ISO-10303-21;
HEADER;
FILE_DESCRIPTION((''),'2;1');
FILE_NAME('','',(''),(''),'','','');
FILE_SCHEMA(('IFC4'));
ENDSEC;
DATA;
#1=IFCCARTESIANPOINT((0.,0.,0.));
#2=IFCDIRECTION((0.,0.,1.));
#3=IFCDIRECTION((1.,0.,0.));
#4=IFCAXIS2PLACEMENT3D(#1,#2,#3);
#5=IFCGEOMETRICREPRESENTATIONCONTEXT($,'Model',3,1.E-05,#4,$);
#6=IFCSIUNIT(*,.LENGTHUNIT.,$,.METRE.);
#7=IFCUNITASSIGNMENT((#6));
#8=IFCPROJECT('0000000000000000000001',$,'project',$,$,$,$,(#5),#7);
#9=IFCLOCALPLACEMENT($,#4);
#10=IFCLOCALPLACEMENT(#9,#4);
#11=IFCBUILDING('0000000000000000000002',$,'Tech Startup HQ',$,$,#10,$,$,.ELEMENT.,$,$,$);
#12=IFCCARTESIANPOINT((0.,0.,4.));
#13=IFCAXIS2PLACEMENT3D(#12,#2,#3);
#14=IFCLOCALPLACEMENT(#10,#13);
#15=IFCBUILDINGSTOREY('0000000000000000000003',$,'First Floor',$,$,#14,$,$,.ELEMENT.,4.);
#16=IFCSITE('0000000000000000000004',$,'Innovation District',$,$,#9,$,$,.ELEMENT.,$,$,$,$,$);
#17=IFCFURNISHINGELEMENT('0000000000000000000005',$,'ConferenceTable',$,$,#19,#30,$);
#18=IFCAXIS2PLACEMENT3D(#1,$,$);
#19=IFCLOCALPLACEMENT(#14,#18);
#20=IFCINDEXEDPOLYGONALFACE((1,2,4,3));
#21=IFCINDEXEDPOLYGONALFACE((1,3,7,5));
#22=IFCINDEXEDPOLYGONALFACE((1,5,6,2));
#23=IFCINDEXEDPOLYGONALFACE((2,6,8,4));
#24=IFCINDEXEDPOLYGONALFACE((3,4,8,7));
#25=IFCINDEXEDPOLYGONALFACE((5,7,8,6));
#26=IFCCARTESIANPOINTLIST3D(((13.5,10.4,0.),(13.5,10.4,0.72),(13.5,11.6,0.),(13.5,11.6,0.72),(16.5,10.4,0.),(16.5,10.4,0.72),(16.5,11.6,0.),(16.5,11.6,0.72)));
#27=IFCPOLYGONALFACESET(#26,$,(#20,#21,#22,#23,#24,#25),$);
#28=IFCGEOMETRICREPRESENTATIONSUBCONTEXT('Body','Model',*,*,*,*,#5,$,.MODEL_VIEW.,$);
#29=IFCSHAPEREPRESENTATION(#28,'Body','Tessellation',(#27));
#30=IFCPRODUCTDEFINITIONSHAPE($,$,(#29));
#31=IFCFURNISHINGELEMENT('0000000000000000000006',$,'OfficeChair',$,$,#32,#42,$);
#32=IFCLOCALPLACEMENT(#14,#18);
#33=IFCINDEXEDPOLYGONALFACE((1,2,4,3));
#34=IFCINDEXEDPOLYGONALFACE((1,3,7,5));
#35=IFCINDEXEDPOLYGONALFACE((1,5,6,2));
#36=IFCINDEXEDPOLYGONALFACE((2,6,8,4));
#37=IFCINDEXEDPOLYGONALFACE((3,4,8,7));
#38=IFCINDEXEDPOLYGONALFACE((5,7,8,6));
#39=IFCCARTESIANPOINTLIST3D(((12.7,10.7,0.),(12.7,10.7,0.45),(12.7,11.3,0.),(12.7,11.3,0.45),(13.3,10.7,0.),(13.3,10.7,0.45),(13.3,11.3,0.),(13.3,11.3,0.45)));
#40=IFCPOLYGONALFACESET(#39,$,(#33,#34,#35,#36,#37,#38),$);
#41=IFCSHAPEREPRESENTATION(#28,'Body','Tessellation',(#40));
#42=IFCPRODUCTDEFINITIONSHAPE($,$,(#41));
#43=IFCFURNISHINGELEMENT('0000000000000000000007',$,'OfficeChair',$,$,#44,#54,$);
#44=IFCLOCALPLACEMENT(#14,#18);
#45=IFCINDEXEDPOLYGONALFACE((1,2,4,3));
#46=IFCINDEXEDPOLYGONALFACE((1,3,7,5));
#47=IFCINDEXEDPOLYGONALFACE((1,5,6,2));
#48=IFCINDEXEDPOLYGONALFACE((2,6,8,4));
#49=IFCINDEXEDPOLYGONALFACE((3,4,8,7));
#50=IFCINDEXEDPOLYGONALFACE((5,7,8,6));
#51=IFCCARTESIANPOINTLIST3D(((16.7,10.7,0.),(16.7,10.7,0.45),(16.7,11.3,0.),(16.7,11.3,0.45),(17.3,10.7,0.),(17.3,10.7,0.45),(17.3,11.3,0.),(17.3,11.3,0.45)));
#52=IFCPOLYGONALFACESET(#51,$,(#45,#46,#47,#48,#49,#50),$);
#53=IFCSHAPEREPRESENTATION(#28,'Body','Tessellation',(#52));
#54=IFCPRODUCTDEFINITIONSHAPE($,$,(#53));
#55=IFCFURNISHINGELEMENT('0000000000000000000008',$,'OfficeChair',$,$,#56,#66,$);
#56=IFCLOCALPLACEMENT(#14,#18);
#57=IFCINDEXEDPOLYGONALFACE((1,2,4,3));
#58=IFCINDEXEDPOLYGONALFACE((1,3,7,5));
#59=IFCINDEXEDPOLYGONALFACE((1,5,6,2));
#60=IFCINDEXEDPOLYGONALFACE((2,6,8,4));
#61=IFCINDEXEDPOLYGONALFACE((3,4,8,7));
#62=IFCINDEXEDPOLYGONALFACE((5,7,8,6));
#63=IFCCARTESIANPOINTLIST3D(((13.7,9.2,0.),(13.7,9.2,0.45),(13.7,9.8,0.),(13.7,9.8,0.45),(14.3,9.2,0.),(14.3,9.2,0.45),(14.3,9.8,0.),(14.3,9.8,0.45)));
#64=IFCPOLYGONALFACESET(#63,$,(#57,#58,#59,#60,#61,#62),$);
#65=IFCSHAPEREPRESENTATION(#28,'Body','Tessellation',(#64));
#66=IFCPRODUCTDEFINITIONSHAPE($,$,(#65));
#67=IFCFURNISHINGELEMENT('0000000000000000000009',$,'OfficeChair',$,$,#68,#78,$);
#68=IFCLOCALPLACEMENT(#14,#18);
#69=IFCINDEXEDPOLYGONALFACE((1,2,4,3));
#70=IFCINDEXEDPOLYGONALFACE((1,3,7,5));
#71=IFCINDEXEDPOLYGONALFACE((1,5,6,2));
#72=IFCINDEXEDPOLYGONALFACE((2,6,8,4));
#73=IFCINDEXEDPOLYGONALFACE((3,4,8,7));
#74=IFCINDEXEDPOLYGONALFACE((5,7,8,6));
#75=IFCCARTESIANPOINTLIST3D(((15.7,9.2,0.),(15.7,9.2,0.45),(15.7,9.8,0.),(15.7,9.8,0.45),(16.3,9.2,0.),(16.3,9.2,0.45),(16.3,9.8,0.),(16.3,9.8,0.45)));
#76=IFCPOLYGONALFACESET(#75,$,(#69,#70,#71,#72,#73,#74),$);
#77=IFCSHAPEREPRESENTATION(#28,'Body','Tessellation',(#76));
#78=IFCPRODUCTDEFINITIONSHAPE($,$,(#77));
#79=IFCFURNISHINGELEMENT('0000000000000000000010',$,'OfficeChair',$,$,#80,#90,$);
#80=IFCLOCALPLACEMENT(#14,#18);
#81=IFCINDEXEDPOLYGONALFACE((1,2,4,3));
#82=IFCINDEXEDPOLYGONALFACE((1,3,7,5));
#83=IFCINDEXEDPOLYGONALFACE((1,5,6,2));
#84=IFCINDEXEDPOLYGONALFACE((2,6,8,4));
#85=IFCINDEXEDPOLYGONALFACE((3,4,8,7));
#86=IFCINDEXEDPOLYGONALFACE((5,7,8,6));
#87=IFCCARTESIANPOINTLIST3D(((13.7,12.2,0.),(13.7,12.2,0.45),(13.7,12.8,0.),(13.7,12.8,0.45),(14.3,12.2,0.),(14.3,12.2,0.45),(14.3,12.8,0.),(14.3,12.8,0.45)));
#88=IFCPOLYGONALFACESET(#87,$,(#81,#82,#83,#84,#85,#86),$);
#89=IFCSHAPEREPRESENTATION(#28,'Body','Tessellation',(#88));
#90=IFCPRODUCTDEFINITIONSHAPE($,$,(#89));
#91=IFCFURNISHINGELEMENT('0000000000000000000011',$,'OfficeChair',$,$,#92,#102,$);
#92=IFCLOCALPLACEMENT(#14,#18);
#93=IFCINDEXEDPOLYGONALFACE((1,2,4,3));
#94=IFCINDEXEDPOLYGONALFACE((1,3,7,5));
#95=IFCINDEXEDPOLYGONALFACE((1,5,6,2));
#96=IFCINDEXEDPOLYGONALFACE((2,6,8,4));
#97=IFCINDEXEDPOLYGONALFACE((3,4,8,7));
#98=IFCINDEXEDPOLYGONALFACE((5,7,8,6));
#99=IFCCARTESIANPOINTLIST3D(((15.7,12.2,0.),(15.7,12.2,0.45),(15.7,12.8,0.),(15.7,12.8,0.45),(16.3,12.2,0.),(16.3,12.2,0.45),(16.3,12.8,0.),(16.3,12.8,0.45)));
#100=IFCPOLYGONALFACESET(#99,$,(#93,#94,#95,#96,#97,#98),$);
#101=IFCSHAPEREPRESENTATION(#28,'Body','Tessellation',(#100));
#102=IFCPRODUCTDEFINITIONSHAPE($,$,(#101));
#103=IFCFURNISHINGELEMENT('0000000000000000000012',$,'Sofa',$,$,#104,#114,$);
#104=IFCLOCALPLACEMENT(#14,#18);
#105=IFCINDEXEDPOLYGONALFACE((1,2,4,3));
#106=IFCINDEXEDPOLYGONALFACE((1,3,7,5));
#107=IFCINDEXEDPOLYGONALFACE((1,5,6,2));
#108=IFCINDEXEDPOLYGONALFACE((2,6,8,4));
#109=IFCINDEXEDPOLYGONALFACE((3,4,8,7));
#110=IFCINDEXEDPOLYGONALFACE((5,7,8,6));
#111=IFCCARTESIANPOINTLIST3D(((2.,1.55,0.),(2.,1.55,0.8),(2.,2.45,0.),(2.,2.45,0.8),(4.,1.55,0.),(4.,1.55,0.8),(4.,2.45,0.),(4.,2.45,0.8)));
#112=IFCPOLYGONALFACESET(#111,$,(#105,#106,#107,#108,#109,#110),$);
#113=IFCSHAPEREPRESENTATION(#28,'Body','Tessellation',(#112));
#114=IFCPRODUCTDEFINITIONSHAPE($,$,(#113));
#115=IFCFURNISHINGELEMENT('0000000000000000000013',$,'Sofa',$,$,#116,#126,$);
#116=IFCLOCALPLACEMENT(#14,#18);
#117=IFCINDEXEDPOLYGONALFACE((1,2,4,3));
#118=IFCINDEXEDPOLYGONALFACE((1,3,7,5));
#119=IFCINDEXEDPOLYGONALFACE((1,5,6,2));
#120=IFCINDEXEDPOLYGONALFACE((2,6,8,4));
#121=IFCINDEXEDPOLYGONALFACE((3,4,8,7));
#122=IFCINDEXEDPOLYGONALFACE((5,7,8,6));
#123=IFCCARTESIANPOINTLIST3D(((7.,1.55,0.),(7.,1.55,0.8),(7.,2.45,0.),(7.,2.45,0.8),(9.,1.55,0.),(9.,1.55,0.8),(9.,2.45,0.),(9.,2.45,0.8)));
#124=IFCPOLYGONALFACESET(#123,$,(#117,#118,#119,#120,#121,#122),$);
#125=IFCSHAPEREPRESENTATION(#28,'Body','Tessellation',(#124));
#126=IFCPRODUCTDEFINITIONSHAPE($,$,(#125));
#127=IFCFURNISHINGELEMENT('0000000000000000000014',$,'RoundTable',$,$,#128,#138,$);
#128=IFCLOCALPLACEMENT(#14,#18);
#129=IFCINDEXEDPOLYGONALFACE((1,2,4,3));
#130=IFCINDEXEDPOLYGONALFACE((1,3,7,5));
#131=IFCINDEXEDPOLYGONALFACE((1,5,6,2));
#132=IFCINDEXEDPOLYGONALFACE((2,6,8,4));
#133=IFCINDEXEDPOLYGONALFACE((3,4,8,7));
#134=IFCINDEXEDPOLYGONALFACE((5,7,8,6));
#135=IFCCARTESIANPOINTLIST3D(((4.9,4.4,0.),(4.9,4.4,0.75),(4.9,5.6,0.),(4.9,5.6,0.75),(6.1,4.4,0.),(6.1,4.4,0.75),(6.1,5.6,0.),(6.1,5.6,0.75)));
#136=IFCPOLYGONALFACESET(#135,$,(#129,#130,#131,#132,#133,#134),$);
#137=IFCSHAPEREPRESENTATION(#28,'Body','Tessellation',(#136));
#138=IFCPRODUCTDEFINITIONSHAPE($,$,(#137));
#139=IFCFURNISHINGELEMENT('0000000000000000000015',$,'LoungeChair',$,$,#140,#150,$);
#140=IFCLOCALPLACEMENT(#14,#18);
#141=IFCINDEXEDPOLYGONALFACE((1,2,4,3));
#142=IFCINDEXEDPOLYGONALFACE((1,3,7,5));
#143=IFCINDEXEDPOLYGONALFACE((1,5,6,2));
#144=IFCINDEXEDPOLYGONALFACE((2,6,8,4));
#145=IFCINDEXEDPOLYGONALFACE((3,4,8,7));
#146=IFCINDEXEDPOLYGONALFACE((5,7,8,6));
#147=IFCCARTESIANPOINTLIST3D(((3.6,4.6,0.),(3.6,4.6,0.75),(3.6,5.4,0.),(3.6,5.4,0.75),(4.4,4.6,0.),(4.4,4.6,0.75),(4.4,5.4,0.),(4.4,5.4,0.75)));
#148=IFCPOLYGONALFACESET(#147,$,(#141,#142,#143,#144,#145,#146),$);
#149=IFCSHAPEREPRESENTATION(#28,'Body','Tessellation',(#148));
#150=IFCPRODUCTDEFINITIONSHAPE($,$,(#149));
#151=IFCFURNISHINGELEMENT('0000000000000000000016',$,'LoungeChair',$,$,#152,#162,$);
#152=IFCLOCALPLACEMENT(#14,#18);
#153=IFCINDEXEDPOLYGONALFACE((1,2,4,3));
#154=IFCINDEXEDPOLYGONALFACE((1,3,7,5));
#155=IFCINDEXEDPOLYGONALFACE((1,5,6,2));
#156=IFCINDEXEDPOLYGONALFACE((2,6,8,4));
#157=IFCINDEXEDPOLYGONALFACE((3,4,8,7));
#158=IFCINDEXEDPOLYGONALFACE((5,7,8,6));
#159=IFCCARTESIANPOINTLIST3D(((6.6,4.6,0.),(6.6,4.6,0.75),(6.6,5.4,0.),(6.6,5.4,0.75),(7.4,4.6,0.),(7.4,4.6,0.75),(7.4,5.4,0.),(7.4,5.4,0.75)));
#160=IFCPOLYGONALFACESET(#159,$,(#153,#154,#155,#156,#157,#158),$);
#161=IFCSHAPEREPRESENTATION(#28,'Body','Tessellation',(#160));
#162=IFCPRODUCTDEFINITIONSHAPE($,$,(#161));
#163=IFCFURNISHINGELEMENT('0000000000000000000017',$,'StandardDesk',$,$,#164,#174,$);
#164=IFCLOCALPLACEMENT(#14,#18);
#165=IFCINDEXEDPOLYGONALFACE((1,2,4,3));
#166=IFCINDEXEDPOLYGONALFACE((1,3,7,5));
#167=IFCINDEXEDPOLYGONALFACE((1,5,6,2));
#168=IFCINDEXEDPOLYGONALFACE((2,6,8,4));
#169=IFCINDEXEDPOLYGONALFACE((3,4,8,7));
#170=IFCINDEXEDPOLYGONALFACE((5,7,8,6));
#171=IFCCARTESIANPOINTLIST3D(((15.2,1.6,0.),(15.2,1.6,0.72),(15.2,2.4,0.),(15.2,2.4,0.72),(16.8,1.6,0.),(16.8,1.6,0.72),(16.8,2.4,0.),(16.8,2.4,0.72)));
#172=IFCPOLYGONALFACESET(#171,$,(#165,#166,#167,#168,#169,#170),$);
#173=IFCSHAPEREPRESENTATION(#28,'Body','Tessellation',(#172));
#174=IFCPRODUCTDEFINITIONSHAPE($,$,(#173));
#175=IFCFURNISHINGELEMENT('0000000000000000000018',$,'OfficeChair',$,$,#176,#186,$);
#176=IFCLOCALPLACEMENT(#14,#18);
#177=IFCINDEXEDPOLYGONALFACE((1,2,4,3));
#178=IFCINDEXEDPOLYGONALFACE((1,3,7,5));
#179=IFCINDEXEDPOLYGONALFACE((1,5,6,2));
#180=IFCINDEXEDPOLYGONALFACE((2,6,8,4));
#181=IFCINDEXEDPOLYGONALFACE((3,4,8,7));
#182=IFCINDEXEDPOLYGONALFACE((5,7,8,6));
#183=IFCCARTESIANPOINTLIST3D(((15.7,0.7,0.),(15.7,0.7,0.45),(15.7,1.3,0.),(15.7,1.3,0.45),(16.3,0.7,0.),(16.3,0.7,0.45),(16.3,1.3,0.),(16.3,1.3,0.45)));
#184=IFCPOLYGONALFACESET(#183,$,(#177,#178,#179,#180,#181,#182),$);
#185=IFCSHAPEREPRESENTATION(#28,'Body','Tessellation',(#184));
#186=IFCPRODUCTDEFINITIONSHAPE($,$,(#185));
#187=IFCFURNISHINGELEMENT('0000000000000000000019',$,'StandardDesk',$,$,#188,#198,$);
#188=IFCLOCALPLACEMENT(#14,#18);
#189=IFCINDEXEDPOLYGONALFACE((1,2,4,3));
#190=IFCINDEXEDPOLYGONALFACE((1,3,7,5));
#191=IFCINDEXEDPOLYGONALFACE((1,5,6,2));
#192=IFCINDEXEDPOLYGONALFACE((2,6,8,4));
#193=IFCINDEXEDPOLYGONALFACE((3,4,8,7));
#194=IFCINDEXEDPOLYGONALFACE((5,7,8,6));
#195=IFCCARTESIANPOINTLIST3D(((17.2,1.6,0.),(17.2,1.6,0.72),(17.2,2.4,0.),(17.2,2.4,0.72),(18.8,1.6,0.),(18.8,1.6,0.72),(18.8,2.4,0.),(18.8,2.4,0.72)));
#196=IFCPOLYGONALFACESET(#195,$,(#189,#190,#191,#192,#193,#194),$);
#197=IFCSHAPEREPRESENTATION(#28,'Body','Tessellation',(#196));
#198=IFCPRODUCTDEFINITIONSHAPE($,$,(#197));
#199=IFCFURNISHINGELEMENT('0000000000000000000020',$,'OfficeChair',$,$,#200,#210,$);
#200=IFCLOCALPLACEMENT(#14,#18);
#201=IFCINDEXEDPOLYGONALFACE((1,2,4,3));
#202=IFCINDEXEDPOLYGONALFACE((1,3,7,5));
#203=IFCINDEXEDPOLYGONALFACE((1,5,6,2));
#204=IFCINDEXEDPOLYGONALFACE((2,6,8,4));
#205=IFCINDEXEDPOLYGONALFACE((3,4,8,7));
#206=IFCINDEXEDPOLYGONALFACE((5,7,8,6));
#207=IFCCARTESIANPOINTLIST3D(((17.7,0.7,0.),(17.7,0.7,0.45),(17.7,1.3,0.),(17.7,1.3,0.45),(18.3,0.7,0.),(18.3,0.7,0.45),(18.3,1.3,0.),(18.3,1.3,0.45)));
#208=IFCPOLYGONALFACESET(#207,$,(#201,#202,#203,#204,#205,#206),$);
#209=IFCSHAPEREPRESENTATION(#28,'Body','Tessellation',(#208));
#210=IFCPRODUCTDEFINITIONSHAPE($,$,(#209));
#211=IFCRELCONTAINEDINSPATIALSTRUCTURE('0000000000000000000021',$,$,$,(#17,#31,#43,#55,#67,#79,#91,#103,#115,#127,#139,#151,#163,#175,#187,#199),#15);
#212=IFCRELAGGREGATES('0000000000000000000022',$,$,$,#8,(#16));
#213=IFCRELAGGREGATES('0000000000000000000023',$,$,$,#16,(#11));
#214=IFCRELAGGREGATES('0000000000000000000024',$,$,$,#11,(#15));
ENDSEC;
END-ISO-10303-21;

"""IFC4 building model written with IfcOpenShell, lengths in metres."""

from ifc_helpers import new_model, si_unit, frame, origin_with_axes, place, context, subcontext, project, spatial, polyline, outline, extrude, element, save


model = new_model("IFC4")

# Units and contexts
model_context = context("Model", 3, precision=1e-05, world=origin_with_axes())
body_context = subcontext(model_context, "Body", "Model", "MODEL_VIEW")
ifc_project = project(units=[si_unit("LENGTHUNIT", "METRE")], contexts=[model_context])

# Site, building, storey
site_placement = place(None, origin_with_axes())
site = spatial("IfcSite", under=ifc_project, at=site_placement, Name="Innovation District", CompositionType="ELEMENT")
building_placement = place(site_placement, origin_with_axes())
building = spatial("IfcBuilding", under=site, at=building_placement, Name="Tech Startup HQ", CompositionType="ELEMENT")
storey_placement = place(building_placement, frame((0.0, 0.0, 4.0), z_axis=(0.0, 0.0, 1.0), x_axis=(1.0, 0.0, 0.0)))
storey = spatial("IfcBuildingStorey", under=building, at=storey_placement, Name="First Floor", CompositionType="ELEMENT", Elevation=4.0)

# Furnishing elements
furnishing_1_placement = place(storey_placement, origin_with_axes())
element("IfcFurnishingElement", 1, at=furnishing_1_placement, inside=storey, Name="ConferenceTable", context=body_context, shape_type="SweptSolid", body=[
    extrude(outline(polyline([(13.5, 10.4, 0.0), (16.5, 10.4, 0.0), (16.5, 11.6, 0.0), (13.5, 11.6, 0.0), (13.5, 10.4, 0.0)])), None, (0.0, 0.0, 1.0), 0.72),
])
furnishing_2_placement = place(storey_placement, origin_with_axes())
element("IfcFurnishingElement", 2, at=furnishing_2_placement, inside=storey, Name="OfficeChair", context=body_context, shape_type="SweptSolid", body=[
    extrude(outline(polyline([(12.7, 11.3, 0.0), (12.7, 10.7, 0.0), (13.3, 10.7, 0.0), (13.3, 11.3, 0.0), (12.7, 11.3, 0.0)])), None, (0.0, 0.0, 1.0), 0.45),
])
furnishing_3_placement = place(storey_placement, origin_with_axes())
element("IfcFurnishingElement", 3, at=furnishing_3_placement, inside=storey, Name="OfficeChair", context=body_context, shape_type="SweptSolid", body=[
    extrude(outline(polyline([(17.3, 10.7, 0.0), (17.3, 11.3, 0.0), (16.7, 11.3, 0.0), (16.7, 10.7, 0.0), (17.3, 10.7, 0.0)])), None, (0.0, 0.0, 1.0), 0.45),
])
furnishing_4_placement = place(storey_placement, origin_with_axes())
element("IfcFurnishingElement", 4, at=furnishing_4_placement, inside=storey, Name="OfficeChair", context=body_context, shape_type="SweptSolid", body=[
    extrude(outline(polyline([(13.7, 9.2, 0.0), (14.3, 9.2, 0.0), (14.3, 9.8, 0.0), (13.7, 9.8, 0.0), (13.7, 9.2, 0.0)])), None, (0.0, 0.0, 1.0), 0.45),
])
furnishing_5_placement = place(storey_placement, origin_with_axes())
element("IfcFurnishingElement", 5, at=furnishing_5_placement, inside=storey, Name="OfficeChair", context=body_context, shape_type="SweptSolid", body=[
    extrude(outline(polyline([(15.7, 9.2, 0.0), (16.3, 9.2, 0.0), (16.3, 9.8, 0.0), (15.7, 9.8, 0.0), (15.7, 9.2, 0.0)])), None, (0.0, 0.0, 1.0), 0.45),
])
furnishing_6_placement = place(storey_placement, origin_with_axes())
element("IfcFurnishingElement", 6, at=furnishing_6_placement, inside=storey, Name="OfficeChair", context=body_context, shape_type="SweptSolid", body=[
    extrude(outline(polyline([(14.3, 12.8, 0.0), (13.7, 12.8, 0.0), (13.7, 12.2, 0.0), (14.3, 12.2, 0.0), (14.3, 12.8, 0.0)])), None, (0.0, 0.0, 1.0), 0.45),
])
furnishing_7_placement = place(storey_placement, origin_with_axes())
element("IfcFurnishingElement", 7, at=furnishing_7_placement, inside=storey, Name="OfficeChair", context=body_context, shape_type="SweptSolid", body=[
    extrude(outline(polyline([(16.3, 12.8, 0.0), (15.7, 12.8, 0.0), (15.7, 12.2, 0.0), (16.3, 12.2, 0.0), (16.3, 12.8, 0.0)])), None, (0.0, 0.0, 1.0), 0.45),
])
furnishing_8_placement = place(storey_placement, origin_with_axes())
element("IfcFurnishingElement", 8, at=furnishing_8_placement, inside=storey, Name="Sofa", context=body_context, shape_type="SweptSolid", body=[
    extrude(outline(polyline([(2.0, 1.55, 0.0), (4.0, 1.55, 0.0), (4.0, 2.45, 0.0), (2.0, 2.45, 0.0), (2.0, 1.55, 0.0)])), None, (0.0, 0.0, 1.0), 0.8),
])
furnishing_9_placement = place(storey_placement, origin_with_axes())
element("IfcFurnishingElement", 9, at=furnishing_9_placement, inside=storey, Name="Sofa", context=body_context, shape_type="SweptSolid", body=[
    extrude(outline(polyline([(7.0, 1.55, 0.0), (9.0, 1.55, 0.0), (9.0, 2.45, 0.0), (7.0, 2.45, 0.0), (7.0, 1.55, 0.0)])), None, (0.0, 0.0, 1.0), 0.8),
])
furnishing_10_placement = place(storey_placement, origin_with_axes())
element("IfcFurnishingElement", 10, at=furnishing_10_placement, inside=storey, Name="RoundTable", context=body_context, shape_type="SweptSolid", body=[
    extrude(outline(polyline([(4.9, 4.4, 0.0), (6.1, 4.4, 0.0), (6.1, 5.6, 0.0), (4.9, 5.6, 0.0), (4.9, 4.4, 0.0)])), None, (0.0, 0.0, 1.0), 0.75),
])
furnishing_11_placement = place(storey_placement, origin_with_axes())
element("IfcFurnishingElement", 11, at=furnishing_11_placement, inside=storey, Name="LoungeChair", context=body_context, shape_type="SweptSolid", body=[
    extrude(outline(polyline([(3.6, 5.4, 0.0), (3.6, 4.6, 0.0), (4.4, 4.6, 0.0), (4.4, 5.4, 0.0), (3.6, 5.4, 0.0)])), None, (0.0, 0.0, 1.0), 0.75),
])
furnishing_12_placement = place(storey_placement, origin_with_axes())
element("IfcFurnishingElement", 12, at=furnishing_12_placement, inside=storey, Name="LoungeChair", context=body_context, shape_type="SweptSolid", body=[
    extrude(outline(polyline([(7.4, 4.6, 0.0), (7.4, 5.4, 0.0), (6.6, 5.4, 0.0), (6.6, 4.6, 0.0), (7.4, 4.6, 0.0)])), None, (0.0, 0.0, 1.0), 0.75),
])
furnishing_13_placement = place(storey_placement, origin_with_axes())
element("IfcFurnishingElement", 13, at=furnishing_13_placement, inside=storey, Name="StandardDesk", context=body_context, shape_type="SweptSolid", body=[
    extrude(outline(polyline([(15.2, 1.6, 0.0), (16.8, 1.6, 0.0), (16.8, 2.4, 0.0), (15.2, 2.4, 0.0), (15.2, 1.6, 0.0)])), None, (0.0, 0.0, 1.0), 0.72),
])
furnishing_14_placement = place(storey_placement, origin_with_axes())
element("IfcFurnishingElement", 14, at=furnishing_14_placement, inside=storey, Name="OfficeChair", context=body_context, shape_type="SweptSolid", body=[
    extrude(outline(polyline([(15.7, 0.7, 0.0), (16.3, 0.7, 0.0), (16.3, 1.3, 0.0), (15.7, 1.3, 0.0), (15.7, 0.7, 0.0)])), None, (0.0, 0.0, 1.0), 0.45),
])
furnishing_15_placement = place(storey_placement, origin_with_axes())
element("IfcFurnishingElement", 15, at=furnishing_15_placement, inside=storey, Name="StandardDesk", context=body_context, shape_type="SweptSolid", body=[
    extrude(outline(polyline([(17.2, 1.6, 0.0), (18.8, 1.6, 0.0), (18.8, 2.4, 0.0), (17.2, 2.4, 0.0), (17.2, 1.6, 0.0)])), None, (0.0, 0.0, 1.0), 0.72),
])
furnishing_16_placement = place(storey_placement, origin_with_axes())
element("IfcFurnishingElement", 16, at=furnishing_16_placement, inside=storey, Name="OfficeChair", context=body_context, shape_type="SweptSolid", body=[
    extrude(outline(polyline([(17.7, 0.7, 0.0), (18.3, 0.7, 0.0), (18.3, 1.3, 0.0), (17.7, 1.3, 0.0), (17.7, 0.7, 0.0)])), None, (0.0, 0.0, 1.0), 0.45),
])

save(model, "model.ifc")
